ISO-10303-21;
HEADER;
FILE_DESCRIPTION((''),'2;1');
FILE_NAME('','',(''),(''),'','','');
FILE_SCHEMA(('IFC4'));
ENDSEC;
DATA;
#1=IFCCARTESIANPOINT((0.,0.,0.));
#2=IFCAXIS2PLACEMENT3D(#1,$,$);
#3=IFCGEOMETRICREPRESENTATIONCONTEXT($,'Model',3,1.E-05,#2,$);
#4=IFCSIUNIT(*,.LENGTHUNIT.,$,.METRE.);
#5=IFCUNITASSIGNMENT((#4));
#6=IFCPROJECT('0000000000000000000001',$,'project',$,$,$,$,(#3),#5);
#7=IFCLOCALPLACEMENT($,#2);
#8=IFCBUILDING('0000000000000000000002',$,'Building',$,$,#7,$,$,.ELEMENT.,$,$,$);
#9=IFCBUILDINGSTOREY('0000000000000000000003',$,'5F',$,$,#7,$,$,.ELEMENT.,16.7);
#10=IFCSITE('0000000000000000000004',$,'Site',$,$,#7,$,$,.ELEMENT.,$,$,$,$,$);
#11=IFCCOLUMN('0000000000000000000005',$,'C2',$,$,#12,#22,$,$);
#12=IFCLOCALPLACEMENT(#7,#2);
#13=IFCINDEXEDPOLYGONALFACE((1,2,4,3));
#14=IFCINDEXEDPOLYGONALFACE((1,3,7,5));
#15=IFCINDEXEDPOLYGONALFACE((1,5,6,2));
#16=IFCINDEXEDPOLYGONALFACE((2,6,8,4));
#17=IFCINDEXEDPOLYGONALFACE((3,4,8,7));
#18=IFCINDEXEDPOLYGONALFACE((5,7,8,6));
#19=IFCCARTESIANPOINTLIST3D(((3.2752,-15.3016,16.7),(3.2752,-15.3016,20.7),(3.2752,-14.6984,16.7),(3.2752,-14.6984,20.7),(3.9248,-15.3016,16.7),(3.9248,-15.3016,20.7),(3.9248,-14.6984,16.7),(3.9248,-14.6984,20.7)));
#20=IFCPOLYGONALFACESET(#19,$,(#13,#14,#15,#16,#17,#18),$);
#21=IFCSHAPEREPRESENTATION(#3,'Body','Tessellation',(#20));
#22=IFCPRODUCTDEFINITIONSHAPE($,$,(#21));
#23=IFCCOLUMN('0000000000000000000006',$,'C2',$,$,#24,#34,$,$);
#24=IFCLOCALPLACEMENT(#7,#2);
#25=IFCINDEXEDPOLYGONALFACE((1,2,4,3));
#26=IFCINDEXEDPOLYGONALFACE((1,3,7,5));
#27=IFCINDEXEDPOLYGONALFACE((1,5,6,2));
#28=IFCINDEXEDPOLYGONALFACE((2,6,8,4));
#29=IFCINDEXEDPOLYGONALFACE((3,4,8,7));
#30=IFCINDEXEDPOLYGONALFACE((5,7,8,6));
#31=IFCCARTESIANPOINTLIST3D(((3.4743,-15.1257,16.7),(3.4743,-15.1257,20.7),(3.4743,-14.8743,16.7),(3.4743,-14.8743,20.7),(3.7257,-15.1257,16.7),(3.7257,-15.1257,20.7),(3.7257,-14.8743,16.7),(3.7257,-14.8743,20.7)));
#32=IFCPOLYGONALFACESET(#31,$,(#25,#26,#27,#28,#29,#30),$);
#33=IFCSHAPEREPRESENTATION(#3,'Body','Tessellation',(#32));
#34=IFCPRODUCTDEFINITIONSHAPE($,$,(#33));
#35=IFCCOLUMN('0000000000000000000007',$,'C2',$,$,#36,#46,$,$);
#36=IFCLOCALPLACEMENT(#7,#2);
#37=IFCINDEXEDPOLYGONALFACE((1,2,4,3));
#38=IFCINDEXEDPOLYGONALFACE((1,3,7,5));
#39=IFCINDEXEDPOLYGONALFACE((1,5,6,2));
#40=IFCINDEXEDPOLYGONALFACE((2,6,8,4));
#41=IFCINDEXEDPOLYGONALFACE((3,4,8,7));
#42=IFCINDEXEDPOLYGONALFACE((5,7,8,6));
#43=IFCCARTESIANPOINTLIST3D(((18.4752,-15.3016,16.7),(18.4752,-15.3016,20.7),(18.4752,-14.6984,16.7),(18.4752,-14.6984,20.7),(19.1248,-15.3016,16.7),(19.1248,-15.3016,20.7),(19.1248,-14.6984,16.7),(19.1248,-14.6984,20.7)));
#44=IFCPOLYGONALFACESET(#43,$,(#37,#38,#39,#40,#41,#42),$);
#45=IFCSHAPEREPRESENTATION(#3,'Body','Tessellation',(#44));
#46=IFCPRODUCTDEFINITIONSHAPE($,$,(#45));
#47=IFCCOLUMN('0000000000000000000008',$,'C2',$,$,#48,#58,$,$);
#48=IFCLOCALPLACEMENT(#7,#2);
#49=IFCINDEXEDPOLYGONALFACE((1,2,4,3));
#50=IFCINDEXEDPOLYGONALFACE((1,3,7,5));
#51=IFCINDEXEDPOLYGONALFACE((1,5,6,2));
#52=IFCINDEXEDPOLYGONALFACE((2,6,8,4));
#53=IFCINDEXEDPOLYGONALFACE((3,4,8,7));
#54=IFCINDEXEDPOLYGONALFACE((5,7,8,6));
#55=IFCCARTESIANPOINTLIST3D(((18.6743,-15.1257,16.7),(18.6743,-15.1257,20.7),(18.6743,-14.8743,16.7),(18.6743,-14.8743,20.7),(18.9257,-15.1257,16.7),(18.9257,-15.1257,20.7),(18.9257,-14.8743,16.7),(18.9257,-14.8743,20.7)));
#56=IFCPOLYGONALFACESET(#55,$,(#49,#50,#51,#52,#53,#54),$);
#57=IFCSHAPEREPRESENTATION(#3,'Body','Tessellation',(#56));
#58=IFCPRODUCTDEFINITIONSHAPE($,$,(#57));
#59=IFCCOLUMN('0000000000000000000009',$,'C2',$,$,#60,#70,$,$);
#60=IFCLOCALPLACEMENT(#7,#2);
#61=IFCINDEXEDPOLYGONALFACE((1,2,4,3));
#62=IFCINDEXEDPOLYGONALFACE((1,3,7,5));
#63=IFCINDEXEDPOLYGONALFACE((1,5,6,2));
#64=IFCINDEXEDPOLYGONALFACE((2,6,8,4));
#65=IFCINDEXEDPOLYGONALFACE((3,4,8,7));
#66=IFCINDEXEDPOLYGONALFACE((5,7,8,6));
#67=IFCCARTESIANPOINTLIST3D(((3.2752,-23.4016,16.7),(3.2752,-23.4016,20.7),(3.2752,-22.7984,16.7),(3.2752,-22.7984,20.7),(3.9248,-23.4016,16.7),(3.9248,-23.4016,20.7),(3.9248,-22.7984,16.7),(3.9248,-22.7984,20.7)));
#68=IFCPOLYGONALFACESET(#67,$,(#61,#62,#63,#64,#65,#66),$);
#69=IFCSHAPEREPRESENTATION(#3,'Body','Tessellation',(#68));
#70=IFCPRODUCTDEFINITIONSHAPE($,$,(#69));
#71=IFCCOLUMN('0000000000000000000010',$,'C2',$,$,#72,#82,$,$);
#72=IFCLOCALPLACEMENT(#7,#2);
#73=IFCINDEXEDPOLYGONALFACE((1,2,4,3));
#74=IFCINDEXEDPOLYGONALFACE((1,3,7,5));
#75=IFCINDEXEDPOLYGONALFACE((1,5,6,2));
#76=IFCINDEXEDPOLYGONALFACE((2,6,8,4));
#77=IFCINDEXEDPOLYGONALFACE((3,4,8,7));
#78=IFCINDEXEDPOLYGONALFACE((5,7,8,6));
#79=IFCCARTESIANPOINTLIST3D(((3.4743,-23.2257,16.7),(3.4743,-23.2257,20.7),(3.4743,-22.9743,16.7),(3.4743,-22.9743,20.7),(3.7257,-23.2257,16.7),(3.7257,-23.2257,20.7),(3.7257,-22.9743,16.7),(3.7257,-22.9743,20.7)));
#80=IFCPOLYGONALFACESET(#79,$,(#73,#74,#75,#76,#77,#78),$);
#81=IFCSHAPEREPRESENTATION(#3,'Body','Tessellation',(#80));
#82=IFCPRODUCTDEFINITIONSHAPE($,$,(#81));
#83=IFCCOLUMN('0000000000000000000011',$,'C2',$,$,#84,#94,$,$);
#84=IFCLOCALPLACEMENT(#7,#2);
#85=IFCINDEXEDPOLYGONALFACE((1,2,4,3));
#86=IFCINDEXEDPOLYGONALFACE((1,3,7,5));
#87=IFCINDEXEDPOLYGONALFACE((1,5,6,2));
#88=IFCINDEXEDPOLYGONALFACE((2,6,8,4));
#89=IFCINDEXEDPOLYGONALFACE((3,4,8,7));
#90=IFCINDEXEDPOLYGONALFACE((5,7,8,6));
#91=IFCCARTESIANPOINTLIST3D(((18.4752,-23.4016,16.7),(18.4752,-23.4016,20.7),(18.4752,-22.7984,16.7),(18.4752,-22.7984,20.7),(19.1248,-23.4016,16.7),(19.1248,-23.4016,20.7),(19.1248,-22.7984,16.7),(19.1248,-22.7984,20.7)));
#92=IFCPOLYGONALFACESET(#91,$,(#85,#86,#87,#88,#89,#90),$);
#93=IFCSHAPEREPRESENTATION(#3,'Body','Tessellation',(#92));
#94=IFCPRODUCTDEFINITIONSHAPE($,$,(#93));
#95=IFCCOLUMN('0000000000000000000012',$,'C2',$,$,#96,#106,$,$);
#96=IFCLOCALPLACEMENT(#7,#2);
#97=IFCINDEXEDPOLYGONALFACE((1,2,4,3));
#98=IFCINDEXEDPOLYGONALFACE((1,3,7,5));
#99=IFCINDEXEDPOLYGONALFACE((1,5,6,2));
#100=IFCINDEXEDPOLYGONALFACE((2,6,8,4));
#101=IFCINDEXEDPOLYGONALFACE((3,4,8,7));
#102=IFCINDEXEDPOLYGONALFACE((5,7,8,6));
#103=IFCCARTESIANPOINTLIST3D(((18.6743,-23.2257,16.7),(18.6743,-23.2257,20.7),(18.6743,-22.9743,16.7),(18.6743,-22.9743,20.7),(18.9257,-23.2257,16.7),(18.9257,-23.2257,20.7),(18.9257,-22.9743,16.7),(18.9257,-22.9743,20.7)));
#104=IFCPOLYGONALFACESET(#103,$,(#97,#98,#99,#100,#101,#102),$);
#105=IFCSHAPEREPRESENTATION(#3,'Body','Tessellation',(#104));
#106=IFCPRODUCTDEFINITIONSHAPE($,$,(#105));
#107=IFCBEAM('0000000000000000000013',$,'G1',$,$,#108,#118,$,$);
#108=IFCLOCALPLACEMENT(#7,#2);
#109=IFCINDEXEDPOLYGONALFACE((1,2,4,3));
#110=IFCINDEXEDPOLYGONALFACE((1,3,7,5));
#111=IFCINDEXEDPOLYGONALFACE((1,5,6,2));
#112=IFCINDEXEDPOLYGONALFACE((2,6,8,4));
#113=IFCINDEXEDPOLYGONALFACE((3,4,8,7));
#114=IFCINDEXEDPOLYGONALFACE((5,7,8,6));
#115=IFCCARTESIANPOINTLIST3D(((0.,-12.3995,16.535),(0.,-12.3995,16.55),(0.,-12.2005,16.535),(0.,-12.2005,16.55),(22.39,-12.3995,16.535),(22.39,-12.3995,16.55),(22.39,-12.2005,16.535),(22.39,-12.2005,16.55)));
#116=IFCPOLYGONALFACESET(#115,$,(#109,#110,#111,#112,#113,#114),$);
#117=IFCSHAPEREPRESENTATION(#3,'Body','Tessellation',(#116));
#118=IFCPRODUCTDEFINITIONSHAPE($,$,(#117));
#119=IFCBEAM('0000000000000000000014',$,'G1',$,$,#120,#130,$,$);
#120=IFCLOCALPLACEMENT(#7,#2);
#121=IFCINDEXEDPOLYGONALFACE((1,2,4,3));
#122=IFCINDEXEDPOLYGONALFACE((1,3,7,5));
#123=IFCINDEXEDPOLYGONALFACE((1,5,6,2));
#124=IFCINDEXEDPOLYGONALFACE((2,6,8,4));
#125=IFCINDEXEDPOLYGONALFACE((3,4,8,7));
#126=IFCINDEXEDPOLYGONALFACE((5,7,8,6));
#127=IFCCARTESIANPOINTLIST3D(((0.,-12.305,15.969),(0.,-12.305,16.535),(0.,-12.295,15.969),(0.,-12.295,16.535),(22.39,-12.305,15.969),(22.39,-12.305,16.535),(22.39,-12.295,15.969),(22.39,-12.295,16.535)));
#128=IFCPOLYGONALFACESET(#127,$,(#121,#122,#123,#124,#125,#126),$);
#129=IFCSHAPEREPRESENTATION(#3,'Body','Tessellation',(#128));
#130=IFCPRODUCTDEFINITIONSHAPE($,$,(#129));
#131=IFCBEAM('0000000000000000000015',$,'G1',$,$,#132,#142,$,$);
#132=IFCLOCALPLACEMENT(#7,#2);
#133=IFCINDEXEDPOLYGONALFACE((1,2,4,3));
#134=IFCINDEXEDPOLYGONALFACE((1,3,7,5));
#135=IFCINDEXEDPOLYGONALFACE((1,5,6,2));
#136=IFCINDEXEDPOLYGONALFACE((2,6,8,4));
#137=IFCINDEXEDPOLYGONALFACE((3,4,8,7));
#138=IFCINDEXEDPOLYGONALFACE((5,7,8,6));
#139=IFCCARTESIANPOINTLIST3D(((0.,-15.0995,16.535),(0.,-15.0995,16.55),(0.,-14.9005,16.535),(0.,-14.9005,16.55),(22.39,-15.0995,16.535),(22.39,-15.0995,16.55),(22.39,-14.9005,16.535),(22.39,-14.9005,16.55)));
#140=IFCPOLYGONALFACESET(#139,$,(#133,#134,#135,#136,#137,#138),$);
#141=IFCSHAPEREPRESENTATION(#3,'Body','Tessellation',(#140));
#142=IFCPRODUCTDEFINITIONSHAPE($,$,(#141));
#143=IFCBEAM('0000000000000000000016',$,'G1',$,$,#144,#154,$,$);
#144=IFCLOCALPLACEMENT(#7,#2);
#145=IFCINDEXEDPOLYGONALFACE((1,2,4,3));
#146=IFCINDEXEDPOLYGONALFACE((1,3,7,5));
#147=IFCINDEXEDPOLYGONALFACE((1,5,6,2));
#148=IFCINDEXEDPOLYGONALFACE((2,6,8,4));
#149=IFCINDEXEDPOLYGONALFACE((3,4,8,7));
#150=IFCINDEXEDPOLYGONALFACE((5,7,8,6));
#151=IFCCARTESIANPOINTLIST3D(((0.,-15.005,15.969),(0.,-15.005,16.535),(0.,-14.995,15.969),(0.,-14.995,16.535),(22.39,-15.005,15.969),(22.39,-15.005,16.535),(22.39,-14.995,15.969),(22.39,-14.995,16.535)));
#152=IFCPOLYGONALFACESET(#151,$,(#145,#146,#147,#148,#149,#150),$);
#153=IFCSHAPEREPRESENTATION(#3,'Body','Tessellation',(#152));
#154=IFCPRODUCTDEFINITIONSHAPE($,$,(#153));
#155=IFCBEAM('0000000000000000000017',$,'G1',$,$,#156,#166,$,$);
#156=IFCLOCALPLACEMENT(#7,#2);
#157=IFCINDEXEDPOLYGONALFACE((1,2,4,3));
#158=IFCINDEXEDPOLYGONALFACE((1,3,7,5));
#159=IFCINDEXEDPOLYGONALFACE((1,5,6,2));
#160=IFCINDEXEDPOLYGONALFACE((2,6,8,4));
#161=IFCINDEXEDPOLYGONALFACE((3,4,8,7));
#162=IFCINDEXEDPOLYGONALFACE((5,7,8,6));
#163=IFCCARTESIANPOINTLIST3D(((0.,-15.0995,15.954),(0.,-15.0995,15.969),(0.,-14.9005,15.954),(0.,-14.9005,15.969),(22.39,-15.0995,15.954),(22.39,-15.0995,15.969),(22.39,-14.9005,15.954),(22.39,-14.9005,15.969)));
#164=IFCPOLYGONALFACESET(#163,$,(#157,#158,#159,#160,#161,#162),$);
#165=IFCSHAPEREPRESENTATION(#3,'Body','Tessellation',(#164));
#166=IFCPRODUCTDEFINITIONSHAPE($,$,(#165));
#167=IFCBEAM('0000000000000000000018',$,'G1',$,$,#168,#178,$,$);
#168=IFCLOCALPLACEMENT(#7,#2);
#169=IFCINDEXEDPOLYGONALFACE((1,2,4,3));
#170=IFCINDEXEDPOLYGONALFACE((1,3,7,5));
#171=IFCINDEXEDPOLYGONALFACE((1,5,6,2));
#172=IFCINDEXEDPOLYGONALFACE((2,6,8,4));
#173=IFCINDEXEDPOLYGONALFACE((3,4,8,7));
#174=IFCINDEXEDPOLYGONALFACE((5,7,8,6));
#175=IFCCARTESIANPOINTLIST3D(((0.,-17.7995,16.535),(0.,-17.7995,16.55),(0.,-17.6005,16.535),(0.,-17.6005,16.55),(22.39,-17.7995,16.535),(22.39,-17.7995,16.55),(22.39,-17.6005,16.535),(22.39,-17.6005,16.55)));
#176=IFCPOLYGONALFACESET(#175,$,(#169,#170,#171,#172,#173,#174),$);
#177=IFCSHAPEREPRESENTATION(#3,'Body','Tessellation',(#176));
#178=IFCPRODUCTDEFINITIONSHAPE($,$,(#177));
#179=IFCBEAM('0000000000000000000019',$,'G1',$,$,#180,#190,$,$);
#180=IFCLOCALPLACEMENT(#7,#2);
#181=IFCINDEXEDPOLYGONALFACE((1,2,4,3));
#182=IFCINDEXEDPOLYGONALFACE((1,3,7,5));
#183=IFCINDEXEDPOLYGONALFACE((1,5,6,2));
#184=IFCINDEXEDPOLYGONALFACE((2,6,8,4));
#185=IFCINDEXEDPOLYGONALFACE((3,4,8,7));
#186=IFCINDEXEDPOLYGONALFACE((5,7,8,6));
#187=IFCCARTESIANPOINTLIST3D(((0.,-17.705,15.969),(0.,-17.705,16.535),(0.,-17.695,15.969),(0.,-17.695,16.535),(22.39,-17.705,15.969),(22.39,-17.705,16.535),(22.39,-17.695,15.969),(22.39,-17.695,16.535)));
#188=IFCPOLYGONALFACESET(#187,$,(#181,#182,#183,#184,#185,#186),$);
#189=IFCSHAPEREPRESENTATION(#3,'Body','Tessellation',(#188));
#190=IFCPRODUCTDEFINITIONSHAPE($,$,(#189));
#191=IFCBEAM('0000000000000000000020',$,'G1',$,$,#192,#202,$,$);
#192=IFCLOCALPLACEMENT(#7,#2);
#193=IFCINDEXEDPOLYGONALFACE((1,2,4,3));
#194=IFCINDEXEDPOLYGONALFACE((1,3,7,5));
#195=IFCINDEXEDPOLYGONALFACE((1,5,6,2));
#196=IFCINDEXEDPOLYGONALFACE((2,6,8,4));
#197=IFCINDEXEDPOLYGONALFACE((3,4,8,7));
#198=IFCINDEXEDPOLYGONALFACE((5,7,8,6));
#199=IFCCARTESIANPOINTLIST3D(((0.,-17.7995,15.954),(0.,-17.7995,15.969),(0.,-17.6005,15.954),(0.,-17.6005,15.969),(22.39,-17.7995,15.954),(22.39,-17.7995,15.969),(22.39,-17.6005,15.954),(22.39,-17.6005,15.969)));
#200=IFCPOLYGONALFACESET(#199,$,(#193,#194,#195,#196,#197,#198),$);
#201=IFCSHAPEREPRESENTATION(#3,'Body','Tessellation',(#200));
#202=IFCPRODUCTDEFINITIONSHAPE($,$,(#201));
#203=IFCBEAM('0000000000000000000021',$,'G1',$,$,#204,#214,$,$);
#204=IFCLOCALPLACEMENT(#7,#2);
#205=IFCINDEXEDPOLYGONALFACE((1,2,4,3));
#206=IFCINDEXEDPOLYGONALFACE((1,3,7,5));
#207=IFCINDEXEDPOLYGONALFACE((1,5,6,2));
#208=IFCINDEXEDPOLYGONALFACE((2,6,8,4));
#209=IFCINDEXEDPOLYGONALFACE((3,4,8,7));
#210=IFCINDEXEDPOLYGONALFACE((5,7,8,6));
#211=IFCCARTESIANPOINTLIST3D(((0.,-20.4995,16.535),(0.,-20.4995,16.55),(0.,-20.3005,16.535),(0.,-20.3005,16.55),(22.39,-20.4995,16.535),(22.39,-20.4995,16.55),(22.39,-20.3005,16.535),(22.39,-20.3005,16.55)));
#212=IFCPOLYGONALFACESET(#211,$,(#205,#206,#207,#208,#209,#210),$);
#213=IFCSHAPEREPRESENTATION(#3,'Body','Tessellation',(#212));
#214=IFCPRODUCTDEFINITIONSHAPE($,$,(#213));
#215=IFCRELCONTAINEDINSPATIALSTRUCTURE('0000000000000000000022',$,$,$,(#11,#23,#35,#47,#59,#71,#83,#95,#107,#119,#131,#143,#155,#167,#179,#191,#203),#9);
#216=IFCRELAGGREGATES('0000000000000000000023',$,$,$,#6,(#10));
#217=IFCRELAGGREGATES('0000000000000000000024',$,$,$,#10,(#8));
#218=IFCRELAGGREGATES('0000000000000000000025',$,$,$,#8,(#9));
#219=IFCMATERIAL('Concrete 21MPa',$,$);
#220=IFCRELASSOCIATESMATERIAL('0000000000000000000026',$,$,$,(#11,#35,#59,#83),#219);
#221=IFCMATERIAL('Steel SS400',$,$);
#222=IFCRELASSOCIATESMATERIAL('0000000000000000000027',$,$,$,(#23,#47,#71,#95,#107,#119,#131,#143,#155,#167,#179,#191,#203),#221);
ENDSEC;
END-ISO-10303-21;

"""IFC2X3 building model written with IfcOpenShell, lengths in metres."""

from ifc_helpers import new_model, si_unit, frame, origin, origin_2d, place, context, project, spatial, rectangle, extrude, material, element, save


model = new_model("IFC2X3")

# Units and contexts
model_context = context("Model", 3, precision=1e-05, world=origin())
ifc_project = project(units=[si_unit("LENGTHUNIT", "METRE")], contexts=[model_context])

# Site, building, storey
placement = place(None, origin())
site = spatial("IfcSite", under=ifc_project, at=placement, Name="Site", CompositionType="ELEMENT")
building = spatial("IfcBuilding", under=site, at=placement, Name="Building", CompositionType="ELEMENT")
storey = spatial("IfcBuildingStorey", under=building, at=placement, Name="5F", CompositionType="ELEMENT", Elevation=16.7)

# Columns
ifc_material_1 = material(Name="Concrete 21MPa")
column_1_placement = place(None, frame((3.6, -15.0, 16.7)))
element("IfcColumn", 1, at=column_1_placement, inside=storey, material=ifc_material_1, Name="C2", context=model_context, shape_type="SweptSolid", body=[
    extrude(rectangle(XDim=0.6496, YDim=0.6032, at=origin_2d()), origin(), (0.0, 0.0, 1.0), 4.0),
])
ifc_material_2 = material(Name="Steel SS400")
column_2_placement = place(None, frame((3.6, -15.0, 16.7)))
element("IfcColumn", 2, at=column_2_placement, inside=storey, material=ifc_material_2, Name="C2", context=model_context, shape_type="SweptSolid", body=[
    extrude(rectangle(XDim=0.2513, YDim=0.2513, at=origin_2d()), origin(), (0.0, 0.0, 1.0), 4.0),
])
column_3_placement = place(None, frame((18.8, -15.0, 16.7)))
element("IfcColumn", 3, at=column_3_placement, inside=storey, material=ifc_material_1, Name="C2", context=model_context, shape_type="SweptSolid", body=[
    extrude(rectangle(XDim=0.6496, YDim=0.6032, at=origin_2d()), origin(), (0.0, 0.0, 1.0), 4.0),
])
column_4_placement = place(None, frame((18.8, -15.0, 16.7)))
element("IfcColumn", 4, at=column_4_placement, inside=storey, material=ifc_material_2, Name="C2", context=model_context, shape_type="SweptSolid", body=[
    extrude(rectangle(XDim=0.2513, YDim=0.2513, at=origin_2d()), origin(), (0.0, 0.0, 1.0), 4.0),
])
column_5_placement = place(None, frame((3.6, -23.1, 16.7)))
element("IfcColumn", 5, at=column_5_placement, inside=storey, material=ifc_material_1, Name="C2", context=model_context, shape_type="SweptSolid", body=[
    extrude(rectangle(XDim=0.6496, YDim=0.6032, at=origin_2d()), origin(), (0.0, 0.0, 1.0), 4.0),
])
column_6_placement = place(None, frame((3.6, -23.1, 16.7)))
element("IfcColumn", 6, at=column_6_placement, inside=storey, material=ifc_material_2, Name="C2", context=model_context, shape_type="SweptSolid", body=[
    extrude(rectangle(XDim=0.2513, YDim=0.2513, at=origin_2d()), origin(), (0.0, 0.0, 1.0), 4.0),
])
column_7_placement = place(None, frame((18.8, -23.1, 16.7)))
element("IfcColumn", 7, at=column_7_placement, inside=storey, material=ifc_material_1, Name="C2", context=model_context, shape_type="SweptSolid", body=[
    extrude(rectangle(XDim=0.6496, YDim=0.6032, at=origin_2d()), origin(), (0.0, 0.0, 1.0), 4.0),
])
column_8_placement = place(None, frame((18.8, -23.1, 16.7)))
element("IfcColumn", 8, at=column_8_placement, inside=storey, material=ifc_material_2, Name="C2", context=model_context, shape_type="SweptSolid", body=[
    extrude(rectangle(XDim=0.2513, YDim=0.2513, at=origin_2d()), origin(), (0.0, 0.0, 1.0), 4.0),
])

# Beams
beam_1_placement = place(None, frame((11.195, -12.3, 16.535)))
element("IfcBeam", 9, at=beam_1_placement, inside=storey, material=ifc_material_2, Name="G1", context=model_context, shape_type="SweptSolid", body=[
    extrude(rectangle(XDim=22.39, YDim=0.199, at=origin_2d()), origin(), (0.0, 0.0, 1.0), 0.015),
])
beam_2_placement = place(None, frame((11.195, -12.3, 15.969)))
element("IfcBeam", 10, at=beam_2_placement, inside=storey, material=ifc_material_2, Name="G1", context=model_context, shape_type="SweptSolid", body=[
    extrude(rectangle(XDim=22.39, YDim=0.01, at=origin_2d()), origin(), (0.0, 0.0, 1.0), 0.566),
])
beam_3_placement = place(None, frame((11.195, -15.0, 16.535)))
element("IfcBeam", 11, at=beam_3_placement, inside=storey, material=ifc_material_2, Name="G1", context=model_context, shape_type="SweptSolid", body=[
    extrude(rectangle(XDim=22.39, YDim=0.199, at=origin_2d()), origin(), (0.0, 0.0, 1.0), 0.015),
])
beam_4_placement = place(None, frame((11.195, -15.0, 15.969)))
element("IfcBeam", 12, at=beam_4_placement, inside=storey, material=ifc_material_2, Name="G1", context=model_context, shape_type="SweptSolid", body=[
    extrude(rectangle(XDim=22.39, YDim=0.01, at=origin_2d()), origin(), (0.0, 0.0, 1.0), 0.566),
])
for number, where, name in (
    (13, (11.195, -15.0, 15.954), "G1"),
    (14, (11.195, -17.7, 16.535), "G1"),
):
    element("IfcBeam", number, at=place(None, frame(where)), inside=storey, material=ifc_material_2, Name=name, context=model_context, shape_type="SweptSolid", body=[
        extrude(rectangle(XDim=22.39, YDim=0.199, at=origin_2d()), origin(), (0.0, 0.0, 1.0), 0.015),
    ])
beam_5_placement = place(None, frame((11.195, -17.7, 15.969)))
element("IfcBeam", 15, at=beam_5_placement, inside=storey, material=ifc_material_2, Name="G1", context=model_context, shape_type="SweptSolid", body=[
    extrude(rectangle(XDim=22.39, YDim=0.01, at=origin_2d()), origin(), (0.0, 0.0, 1.0), 0.566),
])
for number, where, name in (
    (16, (11.195, -17.7, 15.954), "G1"),
    (17, (11.195, -20.4, 16.535), "G1"),
):
    element("IfcBeam", number, at=place(None, frame(where)), inside=storey, material=ifc_material_2, Name=name, context=model_context, shape_type="SweptSolid", body=[
        extrude(rectangle(XDim=22.39, YDim=0.199, at=origin_2d()), origin(), (0.0, 0.0, 1.0), 0.015),
    ])

save(model, "model.ifc")
